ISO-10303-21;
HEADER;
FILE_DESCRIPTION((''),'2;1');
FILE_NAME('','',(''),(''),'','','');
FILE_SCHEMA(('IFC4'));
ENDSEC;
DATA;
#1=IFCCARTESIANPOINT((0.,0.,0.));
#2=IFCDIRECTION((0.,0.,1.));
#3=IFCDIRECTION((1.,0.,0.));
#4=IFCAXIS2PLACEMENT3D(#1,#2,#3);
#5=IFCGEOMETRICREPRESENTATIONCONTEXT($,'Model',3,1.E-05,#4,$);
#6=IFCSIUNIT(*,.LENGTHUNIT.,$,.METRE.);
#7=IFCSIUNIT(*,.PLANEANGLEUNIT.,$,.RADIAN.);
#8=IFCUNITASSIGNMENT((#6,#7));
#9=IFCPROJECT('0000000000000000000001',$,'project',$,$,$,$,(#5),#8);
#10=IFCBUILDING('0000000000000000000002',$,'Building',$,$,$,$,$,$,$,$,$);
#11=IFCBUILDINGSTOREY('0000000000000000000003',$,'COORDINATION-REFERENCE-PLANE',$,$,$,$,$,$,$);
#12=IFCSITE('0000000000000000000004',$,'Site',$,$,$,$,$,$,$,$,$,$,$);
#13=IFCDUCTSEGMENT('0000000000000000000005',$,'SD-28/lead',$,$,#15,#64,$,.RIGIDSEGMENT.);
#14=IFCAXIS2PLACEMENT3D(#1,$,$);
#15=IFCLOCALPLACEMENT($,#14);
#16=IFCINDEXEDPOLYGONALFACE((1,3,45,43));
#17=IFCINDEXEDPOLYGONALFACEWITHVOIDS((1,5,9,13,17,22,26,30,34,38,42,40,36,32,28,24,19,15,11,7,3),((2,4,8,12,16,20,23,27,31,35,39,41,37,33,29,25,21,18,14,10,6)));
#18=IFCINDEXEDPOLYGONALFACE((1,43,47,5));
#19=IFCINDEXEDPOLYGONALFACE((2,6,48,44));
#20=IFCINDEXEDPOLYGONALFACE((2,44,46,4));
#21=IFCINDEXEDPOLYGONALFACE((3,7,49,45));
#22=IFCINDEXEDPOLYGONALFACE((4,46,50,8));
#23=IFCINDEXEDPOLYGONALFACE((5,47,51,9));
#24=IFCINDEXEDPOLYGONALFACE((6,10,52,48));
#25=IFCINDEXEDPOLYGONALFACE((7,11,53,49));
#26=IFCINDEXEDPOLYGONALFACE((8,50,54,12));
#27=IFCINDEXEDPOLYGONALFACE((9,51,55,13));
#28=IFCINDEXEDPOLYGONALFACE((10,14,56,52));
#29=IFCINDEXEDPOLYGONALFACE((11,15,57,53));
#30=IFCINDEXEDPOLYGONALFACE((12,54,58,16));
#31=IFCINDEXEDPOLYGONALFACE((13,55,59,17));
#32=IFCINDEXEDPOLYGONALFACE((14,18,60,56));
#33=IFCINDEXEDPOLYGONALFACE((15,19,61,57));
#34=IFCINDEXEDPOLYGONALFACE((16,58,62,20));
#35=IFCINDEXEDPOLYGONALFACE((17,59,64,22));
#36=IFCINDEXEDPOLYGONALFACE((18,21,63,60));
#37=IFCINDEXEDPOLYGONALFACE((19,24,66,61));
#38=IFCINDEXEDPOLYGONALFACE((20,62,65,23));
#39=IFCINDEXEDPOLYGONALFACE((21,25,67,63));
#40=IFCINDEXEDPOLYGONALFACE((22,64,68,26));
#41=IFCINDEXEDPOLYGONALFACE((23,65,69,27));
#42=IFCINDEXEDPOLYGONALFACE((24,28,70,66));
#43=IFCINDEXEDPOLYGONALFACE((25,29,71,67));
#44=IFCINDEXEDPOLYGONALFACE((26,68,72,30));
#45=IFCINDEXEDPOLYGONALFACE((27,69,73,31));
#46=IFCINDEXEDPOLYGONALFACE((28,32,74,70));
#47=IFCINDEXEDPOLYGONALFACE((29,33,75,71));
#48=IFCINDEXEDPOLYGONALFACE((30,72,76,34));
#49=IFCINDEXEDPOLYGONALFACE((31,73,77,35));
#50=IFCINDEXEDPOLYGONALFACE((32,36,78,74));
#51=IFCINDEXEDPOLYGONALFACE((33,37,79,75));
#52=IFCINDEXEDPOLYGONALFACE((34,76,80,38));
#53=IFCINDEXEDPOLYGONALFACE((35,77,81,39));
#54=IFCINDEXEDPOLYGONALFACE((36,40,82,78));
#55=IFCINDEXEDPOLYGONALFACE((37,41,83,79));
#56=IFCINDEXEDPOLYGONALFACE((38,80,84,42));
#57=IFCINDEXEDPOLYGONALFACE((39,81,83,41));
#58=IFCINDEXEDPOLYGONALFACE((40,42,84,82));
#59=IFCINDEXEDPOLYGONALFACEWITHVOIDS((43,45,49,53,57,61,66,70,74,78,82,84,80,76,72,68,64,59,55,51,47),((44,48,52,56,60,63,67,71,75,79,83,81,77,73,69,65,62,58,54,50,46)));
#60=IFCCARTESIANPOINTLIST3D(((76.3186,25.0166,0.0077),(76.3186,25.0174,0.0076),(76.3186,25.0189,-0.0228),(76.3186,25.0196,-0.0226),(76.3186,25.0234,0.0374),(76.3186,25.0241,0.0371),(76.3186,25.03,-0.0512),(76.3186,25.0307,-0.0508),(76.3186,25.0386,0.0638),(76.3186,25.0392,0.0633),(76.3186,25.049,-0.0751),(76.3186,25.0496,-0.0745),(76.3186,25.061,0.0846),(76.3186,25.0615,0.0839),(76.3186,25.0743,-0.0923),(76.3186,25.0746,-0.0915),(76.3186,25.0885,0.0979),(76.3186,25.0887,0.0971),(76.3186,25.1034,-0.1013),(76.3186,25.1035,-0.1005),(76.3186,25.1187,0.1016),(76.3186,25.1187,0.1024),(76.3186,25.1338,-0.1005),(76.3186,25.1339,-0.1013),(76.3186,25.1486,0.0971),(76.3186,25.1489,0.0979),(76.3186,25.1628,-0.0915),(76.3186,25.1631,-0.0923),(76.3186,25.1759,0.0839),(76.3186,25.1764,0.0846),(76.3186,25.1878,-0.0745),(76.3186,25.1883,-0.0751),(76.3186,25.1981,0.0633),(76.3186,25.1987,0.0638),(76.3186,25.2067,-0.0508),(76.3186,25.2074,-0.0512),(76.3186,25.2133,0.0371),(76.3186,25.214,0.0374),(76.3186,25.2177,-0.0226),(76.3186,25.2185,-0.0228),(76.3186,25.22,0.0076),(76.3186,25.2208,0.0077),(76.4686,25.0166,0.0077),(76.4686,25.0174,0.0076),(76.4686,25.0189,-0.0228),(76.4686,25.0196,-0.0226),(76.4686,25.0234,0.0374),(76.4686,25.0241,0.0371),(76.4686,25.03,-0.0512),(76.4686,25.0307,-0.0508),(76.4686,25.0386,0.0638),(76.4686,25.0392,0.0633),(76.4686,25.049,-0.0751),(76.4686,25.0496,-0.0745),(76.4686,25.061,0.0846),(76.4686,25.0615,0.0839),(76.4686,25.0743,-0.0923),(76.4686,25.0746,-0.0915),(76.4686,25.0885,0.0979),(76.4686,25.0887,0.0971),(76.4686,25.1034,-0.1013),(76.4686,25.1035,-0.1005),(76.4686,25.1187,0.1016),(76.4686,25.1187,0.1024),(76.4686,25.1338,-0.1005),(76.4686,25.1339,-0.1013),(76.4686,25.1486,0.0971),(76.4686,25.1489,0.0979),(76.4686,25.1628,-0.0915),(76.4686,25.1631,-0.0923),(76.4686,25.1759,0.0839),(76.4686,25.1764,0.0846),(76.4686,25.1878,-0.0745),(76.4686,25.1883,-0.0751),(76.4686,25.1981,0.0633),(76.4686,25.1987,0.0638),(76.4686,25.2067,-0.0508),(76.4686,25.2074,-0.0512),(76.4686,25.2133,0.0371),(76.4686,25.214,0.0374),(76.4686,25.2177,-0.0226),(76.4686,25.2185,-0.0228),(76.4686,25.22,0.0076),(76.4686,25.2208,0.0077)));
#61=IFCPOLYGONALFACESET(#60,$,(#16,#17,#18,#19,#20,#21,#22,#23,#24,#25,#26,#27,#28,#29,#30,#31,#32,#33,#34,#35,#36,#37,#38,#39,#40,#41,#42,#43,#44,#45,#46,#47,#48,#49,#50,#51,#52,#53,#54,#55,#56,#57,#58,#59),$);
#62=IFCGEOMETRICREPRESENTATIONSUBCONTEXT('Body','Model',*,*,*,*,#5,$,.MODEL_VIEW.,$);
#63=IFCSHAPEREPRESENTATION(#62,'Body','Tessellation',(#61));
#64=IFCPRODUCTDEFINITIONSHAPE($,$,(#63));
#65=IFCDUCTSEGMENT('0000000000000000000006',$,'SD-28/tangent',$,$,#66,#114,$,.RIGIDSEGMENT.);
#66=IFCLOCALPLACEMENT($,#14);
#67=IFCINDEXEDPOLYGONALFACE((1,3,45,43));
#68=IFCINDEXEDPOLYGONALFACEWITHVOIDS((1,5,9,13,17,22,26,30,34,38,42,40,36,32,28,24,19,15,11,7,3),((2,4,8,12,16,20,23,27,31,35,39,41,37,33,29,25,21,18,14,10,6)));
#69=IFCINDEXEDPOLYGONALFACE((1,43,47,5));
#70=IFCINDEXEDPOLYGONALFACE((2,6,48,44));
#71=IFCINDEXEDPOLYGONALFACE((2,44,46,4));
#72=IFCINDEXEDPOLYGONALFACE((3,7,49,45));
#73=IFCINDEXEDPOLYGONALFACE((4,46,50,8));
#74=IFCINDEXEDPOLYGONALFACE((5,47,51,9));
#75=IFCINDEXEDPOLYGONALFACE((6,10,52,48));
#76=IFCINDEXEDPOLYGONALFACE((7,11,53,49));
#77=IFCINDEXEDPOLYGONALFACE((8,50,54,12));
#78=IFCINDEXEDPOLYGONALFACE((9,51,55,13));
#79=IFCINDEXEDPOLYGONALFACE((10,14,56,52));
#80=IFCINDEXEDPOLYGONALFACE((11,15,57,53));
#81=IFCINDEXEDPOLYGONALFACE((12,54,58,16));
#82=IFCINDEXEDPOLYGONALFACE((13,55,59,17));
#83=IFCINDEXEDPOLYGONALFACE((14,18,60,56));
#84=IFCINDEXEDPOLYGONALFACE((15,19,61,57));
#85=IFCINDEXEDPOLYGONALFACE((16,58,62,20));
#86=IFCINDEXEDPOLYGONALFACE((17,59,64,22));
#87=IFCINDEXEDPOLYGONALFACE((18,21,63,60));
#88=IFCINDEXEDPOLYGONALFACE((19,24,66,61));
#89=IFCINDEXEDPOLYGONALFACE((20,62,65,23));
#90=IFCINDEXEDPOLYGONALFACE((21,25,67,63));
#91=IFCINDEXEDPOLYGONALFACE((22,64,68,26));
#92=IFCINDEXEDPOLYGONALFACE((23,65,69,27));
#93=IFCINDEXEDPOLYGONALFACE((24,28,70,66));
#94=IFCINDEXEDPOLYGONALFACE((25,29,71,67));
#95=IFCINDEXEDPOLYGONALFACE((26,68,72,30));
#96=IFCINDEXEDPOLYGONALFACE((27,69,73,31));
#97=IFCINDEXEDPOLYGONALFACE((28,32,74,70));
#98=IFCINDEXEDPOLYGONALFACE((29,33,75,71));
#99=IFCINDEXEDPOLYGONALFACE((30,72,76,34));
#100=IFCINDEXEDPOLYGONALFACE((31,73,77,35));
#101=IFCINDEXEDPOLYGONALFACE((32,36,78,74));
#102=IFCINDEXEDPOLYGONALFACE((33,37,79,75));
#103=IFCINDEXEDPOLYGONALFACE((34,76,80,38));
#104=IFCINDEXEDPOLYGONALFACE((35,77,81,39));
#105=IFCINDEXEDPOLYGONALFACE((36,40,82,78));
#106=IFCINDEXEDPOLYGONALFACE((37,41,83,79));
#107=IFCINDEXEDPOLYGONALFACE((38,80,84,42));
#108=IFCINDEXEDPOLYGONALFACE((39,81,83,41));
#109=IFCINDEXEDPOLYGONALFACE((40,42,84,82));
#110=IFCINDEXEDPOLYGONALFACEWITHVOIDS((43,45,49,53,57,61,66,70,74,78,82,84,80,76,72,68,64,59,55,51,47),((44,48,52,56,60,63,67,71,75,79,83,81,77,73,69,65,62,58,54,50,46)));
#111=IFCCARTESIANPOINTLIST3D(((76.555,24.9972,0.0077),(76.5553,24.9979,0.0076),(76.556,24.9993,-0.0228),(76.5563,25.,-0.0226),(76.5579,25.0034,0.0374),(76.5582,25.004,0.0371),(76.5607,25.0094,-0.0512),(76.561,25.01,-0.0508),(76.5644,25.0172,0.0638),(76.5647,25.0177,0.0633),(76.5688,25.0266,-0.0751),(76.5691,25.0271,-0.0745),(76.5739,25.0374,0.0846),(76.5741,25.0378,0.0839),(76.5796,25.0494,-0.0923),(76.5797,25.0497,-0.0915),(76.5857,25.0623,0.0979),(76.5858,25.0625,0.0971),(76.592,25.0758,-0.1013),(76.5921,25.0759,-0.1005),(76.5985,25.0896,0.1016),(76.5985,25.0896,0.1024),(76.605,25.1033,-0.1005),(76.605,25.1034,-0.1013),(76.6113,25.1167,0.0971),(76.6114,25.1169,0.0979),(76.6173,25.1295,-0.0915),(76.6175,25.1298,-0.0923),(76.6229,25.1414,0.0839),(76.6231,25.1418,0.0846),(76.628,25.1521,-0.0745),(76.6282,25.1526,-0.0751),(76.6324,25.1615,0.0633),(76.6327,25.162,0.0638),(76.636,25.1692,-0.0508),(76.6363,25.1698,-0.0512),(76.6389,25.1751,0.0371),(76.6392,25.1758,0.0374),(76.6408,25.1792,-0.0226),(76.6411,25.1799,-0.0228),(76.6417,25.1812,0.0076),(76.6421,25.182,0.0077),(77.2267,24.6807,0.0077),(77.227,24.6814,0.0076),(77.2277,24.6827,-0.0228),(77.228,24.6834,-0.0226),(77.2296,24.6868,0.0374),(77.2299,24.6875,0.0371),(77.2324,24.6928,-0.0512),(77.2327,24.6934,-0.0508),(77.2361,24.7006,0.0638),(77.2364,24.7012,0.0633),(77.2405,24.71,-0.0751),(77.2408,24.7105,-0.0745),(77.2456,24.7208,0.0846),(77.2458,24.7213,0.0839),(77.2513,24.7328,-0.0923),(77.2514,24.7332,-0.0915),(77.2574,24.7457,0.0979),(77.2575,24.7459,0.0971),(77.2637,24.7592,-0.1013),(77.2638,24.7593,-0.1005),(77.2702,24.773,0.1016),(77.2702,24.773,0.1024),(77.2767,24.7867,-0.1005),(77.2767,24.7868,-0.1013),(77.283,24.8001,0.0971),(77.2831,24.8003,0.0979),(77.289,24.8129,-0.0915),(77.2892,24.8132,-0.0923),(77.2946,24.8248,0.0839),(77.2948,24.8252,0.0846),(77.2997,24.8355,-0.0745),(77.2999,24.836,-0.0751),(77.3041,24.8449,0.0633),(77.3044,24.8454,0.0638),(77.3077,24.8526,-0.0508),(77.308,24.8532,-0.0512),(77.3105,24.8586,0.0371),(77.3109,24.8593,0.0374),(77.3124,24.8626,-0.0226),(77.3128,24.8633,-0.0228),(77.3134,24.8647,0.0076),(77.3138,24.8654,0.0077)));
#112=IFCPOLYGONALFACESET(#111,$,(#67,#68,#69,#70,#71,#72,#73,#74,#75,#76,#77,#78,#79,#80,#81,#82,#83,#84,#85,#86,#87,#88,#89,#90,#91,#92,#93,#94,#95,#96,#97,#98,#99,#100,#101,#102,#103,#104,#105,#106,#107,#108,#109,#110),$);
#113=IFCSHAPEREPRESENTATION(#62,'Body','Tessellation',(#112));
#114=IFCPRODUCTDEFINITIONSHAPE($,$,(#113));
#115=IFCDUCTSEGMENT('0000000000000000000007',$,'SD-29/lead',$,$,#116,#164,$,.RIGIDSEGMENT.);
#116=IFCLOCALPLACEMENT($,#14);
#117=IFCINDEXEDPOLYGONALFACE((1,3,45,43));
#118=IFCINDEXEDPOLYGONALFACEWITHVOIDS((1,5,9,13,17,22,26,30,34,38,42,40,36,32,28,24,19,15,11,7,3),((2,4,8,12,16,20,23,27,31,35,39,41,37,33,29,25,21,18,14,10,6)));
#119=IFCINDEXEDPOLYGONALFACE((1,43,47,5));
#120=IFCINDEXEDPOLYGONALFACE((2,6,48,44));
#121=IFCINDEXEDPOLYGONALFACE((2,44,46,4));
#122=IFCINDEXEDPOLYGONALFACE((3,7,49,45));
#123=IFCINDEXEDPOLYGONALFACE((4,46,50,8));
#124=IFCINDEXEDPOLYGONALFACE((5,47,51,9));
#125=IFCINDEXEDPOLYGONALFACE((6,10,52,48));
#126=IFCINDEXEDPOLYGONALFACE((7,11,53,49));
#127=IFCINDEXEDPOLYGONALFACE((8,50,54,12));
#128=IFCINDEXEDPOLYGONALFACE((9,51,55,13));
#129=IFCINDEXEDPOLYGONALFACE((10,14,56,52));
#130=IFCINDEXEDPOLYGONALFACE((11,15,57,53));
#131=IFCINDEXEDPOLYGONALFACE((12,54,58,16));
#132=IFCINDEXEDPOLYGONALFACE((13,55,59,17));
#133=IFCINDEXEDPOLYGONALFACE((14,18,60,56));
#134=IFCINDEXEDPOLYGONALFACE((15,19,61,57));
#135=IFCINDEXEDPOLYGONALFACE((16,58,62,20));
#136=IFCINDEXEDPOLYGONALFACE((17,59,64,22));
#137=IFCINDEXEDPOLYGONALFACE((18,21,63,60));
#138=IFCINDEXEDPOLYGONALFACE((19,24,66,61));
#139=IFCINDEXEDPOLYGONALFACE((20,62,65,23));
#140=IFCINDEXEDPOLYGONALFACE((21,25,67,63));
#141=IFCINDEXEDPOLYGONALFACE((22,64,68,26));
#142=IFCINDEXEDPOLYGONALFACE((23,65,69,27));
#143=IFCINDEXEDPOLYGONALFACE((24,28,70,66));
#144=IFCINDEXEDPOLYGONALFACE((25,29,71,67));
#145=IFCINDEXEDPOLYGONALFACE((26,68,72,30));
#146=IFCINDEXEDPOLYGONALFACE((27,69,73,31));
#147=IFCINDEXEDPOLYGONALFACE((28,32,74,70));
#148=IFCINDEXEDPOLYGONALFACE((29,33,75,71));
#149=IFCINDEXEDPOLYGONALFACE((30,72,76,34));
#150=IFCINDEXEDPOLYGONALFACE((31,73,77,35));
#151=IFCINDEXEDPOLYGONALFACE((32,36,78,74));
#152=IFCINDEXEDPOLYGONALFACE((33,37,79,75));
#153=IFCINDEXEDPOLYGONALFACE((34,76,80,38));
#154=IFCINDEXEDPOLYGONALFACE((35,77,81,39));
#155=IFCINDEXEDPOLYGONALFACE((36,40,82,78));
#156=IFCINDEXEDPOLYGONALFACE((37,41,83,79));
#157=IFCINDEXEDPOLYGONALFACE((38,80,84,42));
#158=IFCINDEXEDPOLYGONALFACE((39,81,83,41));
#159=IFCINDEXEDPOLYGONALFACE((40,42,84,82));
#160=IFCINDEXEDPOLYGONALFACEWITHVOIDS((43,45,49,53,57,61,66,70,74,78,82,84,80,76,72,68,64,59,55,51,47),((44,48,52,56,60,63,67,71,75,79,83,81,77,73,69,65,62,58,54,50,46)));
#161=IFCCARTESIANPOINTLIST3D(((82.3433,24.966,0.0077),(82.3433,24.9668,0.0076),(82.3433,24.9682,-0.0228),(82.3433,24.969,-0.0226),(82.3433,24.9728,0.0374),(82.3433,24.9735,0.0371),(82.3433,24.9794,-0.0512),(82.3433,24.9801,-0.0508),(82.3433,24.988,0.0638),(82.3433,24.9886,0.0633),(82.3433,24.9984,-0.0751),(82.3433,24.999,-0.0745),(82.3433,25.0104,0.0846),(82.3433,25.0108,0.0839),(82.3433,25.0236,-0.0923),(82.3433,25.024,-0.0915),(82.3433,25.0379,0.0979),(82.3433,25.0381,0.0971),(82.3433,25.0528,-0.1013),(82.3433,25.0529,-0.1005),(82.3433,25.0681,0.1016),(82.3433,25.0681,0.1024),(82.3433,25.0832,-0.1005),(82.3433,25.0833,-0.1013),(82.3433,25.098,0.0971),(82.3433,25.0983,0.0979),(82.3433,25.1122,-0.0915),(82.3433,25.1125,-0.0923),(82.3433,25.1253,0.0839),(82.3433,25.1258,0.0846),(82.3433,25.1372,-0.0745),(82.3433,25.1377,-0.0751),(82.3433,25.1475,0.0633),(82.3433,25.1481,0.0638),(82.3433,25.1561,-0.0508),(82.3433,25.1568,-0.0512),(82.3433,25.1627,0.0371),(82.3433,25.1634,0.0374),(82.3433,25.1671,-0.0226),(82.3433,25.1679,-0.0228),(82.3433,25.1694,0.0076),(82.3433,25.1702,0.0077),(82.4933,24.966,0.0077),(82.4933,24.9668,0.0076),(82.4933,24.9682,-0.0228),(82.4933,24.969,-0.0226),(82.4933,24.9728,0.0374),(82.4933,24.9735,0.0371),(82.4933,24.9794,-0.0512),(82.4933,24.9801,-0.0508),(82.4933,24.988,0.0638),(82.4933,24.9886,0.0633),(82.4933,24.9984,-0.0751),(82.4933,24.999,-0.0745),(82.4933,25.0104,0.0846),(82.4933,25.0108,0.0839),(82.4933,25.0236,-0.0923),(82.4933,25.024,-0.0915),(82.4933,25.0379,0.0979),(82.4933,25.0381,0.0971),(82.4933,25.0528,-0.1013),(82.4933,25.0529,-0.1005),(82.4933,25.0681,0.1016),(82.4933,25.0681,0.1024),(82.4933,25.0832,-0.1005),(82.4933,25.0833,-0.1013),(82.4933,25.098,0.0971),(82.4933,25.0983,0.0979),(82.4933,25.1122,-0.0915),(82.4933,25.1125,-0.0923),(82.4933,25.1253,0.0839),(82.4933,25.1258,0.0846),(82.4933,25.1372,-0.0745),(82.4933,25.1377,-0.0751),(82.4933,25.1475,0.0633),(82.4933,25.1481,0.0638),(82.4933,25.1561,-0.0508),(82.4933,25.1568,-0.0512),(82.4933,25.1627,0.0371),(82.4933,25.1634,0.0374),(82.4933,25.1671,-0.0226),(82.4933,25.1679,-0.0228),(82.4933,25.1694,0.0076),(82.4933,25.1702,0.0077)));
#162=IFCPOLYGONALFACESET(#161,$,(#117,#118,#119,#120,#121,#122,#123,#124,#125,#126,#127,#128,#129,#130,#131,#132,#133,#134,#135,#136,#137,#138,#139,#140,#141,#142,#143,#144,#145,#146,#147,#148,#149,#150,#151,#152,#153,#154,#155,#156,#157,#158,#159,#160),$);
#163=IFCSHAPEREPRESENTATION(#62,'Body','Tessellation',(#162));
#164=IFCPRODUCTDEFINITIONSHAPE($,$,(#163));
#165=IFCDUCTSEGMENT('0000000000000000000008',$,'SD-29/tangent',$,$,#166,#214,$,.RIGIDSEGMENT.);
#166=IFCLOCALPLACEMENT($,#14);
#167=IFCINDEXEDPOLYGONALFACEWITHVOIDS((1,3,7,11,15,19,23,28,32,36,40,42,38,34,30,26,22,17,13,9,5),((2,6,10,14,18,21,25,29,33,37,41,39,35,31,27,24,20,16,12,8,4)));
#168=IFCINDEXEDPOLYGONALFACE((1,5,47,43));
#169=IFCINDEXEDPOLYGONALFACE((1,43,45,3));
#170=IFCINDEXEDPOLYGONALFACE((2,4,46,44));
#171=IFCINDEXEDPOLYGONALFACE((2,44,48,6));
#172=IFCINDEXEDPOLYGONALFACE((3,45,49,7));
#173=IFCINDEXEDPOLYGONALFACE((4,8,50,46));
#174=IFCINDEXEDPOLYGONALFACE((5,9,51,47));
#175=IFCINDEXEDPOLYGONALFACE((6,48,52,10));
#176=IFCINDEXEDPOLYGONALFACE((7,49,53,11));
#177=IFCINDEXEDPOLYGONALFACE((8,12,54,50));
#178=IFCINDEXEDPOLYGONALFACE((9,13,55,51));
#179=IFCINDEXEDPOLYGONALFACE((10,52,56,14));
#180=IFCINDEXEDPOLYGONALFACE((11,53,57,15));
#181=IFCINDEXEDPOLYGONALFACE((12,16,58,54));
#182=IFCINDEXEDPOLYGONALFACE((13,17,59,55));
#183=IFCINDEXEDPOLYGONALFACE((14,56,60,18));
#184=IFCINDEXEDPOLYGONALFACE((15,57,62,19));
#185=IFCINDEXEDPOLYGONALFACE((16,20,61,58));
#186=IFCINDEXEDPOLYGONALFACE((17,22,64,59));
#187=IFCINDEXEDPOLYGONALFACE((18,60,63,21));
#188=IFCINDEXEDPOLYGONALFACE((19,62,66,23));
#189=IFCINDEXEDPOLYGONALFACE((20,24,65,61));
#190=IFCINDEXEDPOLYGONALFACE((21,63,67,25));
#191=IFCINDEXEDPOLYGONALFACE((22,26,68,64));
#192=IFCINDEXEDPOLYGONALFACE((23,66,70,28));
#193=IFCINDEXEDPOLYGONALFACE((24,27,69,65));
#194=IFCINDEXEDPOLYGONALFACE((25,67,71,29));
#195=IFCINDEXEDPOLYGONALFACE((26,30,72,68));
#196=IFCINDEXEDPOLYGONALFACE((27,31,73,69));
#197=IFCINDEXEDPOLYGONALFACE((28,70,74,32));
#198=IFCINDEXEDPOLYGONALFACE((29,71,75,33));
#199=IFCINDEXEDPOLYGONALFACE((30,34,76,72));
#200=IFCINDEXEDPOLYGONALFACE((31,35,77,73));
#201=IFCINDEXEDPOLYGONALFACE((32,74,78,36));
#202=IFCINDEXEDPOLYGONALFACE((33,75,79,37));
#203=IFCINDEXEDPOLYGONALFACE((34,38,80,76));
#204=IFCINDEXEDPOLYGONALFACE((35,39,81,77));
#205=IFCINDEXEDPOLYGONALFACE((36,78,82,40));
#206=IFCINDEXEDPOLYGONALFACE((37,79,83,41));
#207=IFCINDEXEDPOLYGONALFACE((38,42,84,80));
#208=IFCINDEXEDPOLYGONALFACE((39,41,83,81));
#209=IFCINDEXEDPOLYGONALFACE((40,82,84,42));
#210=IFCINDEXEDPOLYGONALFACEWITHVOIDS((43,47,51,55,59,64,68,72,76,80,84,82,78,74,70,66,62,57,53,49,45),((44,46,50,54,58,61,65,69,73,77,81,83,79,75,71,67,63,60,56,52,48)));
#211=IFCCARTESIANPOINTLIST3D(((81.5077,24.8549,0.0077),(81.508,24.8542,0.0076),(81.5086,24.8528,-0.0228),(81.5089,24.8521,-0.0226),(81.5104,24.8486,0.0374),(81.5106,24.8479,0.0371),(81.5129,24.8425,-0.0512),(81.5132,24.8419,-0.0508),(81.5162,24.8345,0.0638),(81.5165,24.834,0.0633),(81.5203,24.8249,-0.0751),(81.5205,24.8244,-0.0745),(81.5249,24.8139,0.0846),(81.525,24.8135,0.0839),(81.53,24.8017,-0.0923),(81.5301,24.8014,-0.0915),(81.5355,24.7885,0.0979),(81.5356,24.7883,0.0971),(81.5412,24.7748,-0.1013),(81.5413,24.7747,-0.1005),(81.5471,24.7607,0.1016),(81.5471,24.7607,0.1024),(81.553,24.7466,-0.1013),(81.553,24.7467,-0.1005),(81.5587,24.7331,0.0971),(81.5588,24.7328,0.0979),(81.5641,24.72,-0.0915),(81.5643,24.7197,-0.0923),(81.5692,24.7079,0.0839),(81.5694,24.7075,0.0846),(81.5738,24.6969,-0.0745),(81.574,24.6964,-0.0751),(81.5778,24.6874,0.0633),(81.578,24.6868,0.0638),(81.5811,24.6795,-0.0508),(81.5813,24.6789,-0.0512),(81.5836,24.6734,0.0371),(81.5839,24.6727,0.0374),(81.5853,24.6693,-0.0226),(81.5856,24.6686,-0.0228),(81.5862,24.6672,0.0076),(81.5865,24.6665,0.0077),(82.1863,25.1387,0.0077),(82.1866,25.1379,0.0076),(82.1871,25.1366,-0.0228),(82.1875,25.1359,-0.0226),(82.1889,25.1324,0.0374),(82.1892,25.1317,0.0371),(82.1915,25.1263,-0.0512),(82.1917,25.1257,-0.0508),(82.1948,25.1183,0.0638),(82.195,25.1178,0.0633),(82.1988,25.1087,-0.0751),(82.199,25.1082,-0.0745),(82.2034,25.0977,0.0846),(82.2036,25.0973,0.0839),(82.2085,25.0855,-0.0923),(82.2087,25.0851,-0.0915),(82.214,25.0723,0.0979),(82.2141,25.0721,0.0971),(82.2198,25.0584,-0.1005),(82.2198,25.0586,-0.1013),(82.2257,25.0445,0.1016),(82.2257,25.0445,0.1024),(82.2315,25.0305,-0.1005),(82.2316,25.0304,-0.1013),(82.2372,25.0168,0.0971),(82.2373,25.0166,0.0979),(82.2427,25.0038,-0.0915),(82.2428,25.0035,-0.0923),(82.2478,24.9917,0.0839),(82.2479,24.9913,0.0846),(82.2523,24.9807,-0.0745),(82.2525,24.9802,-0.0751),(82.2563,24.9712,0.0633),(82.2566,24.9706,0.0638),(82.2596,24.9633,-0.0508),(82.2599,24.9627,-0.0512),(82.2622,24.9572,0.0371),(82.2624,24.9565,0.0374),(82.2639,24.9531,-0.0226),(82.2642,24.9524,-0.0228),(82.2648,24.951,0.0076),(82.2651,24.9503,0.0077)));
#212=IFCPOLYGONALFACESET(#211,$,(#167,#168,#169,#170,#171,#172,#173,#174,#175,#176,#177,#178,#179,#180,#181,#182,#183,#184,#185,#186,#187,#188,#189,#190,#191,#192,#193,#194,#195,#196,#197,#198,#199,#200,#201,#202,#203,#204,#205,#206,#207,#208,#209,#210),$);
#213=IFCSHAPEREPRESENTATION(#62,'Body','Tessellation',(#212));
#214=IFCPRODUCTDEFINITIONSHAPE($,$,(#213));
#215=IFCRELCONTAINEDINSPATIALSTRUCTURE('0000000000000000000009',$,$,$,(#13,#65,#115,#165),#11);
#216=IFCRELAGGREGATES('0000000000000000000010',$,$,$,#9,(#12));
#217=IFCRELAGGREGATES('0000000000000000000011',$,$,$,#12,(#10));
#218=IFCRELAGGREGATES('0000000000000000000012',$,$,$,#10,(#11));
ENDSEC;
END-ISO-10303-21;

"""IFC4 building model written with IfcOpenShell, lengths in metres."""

from ifc_helpers import new_model, si_unit, frame, origin_with_axes, place, context, subcontext, project, spatial, hollow_circle, extrude, element, save


model = new_model("IFC4")

# Units and contexts
model_context = context("Model", 3, precision=1e-05, world=origin_with_axes())
body_context_1 = subcontext(model_context, "Body", "Model", "MODEL_VIEW")
ifc_project = project(units=[si_unit("LENGTHUNIT", "METRE"), si_unit("PLANEANGLEUNIT", "RADIAN")], contexts=[model_context])

# Site, building, storey
site = spatial("IfcSite", under=ifc_project, Name="Site")
building = spatial("IfcBuilding", under=site, Name="Building")
storey = spatial("IfcBuildingStorey", under=building, Name="COORDINATION-REFERENCE-PLANE")

# Duct segment
duct_segment_1_placement = place(None, frame((76.3186, 25.1187, 0.0), z_axis=(1.0, 0.0, 0.0), x_axis=(0.0, 0.0, 1.0)))
element("IfcDuctSegment", 1, at=duct_segment_1_placement, inside=storey, Name="SD-28/lead", PredefinedType="RIGIDSEGMENT", context=body_context_1, shape_type="SweptSolid", body=[
    extrude(hollow_circle(Radius=0.1024, WallThickness=0.0008), origin_with_axes(), (0.0, 0.0, 1.0), 0.15),
])

# Duct segment
duct_segment_2_placement = place(None, frame((76.5985, 25.0896, 0.0), z_axis=(0.904569, -0.426327, 0.0), x_axis=(0.0, 0.0, 1.0)))
element("IfcDuctSegment", 2, at=duct_segment_2_placement, inside=storey, Name="SD-28/tangent", PredefinedType="RIGIDSEGMENT", context=body_context_1, shape_type="SweptSolid", body=[
    extrude(hollow_circle(Radius=0.1024, WallThickness=0.0008), origin_with_axes(), (0.0, 0.0, 1.0), 0.7425),
])

# Duct segment
duct_segment_3_placement = place(None, frame((82.4933, 25.0681, 0.0), z_axis=(-1.0, 0.0, 0.0), x_axis=(0.0, 0.0, 1.0)))
element("IfcDuctSegment", 3, at=duct_segment_3_placement, inside=storey, Name="SD-29/lead", PredefinedType="RIGIDSEGMENT", context=body_context_1, shape_type="SweptSolid", body=[
    extrude(hollow_circle(Radius=0.1024, WallThickness=0.0008), origin_with_axes(), (0.0, 0.0, 1.0), 0.15),
])

# Duct segment
duct_segment_4_placement = place(None, frame((82.2257, 25.0445, 0.0), z_axis=(-0.922564, -0.385845, 0.0), x_axis=(0.0, 0.0, 1.0)))
element("IfcDuctSegment", 4, at=duct_segment_4_placement, inside=storey, Name="SD-29/tangent", PredefinedType="RIGIDSEGMENT", context=body_context_1, shape_type="SweptSolid", body=[
    extrude(hollow_circle(Radius=0.1024, WallThickness=0.0008), origin_with_axes(), (0.0, 0.0, 1.0), 0.7355),
])

save(model, "model.ifc")
